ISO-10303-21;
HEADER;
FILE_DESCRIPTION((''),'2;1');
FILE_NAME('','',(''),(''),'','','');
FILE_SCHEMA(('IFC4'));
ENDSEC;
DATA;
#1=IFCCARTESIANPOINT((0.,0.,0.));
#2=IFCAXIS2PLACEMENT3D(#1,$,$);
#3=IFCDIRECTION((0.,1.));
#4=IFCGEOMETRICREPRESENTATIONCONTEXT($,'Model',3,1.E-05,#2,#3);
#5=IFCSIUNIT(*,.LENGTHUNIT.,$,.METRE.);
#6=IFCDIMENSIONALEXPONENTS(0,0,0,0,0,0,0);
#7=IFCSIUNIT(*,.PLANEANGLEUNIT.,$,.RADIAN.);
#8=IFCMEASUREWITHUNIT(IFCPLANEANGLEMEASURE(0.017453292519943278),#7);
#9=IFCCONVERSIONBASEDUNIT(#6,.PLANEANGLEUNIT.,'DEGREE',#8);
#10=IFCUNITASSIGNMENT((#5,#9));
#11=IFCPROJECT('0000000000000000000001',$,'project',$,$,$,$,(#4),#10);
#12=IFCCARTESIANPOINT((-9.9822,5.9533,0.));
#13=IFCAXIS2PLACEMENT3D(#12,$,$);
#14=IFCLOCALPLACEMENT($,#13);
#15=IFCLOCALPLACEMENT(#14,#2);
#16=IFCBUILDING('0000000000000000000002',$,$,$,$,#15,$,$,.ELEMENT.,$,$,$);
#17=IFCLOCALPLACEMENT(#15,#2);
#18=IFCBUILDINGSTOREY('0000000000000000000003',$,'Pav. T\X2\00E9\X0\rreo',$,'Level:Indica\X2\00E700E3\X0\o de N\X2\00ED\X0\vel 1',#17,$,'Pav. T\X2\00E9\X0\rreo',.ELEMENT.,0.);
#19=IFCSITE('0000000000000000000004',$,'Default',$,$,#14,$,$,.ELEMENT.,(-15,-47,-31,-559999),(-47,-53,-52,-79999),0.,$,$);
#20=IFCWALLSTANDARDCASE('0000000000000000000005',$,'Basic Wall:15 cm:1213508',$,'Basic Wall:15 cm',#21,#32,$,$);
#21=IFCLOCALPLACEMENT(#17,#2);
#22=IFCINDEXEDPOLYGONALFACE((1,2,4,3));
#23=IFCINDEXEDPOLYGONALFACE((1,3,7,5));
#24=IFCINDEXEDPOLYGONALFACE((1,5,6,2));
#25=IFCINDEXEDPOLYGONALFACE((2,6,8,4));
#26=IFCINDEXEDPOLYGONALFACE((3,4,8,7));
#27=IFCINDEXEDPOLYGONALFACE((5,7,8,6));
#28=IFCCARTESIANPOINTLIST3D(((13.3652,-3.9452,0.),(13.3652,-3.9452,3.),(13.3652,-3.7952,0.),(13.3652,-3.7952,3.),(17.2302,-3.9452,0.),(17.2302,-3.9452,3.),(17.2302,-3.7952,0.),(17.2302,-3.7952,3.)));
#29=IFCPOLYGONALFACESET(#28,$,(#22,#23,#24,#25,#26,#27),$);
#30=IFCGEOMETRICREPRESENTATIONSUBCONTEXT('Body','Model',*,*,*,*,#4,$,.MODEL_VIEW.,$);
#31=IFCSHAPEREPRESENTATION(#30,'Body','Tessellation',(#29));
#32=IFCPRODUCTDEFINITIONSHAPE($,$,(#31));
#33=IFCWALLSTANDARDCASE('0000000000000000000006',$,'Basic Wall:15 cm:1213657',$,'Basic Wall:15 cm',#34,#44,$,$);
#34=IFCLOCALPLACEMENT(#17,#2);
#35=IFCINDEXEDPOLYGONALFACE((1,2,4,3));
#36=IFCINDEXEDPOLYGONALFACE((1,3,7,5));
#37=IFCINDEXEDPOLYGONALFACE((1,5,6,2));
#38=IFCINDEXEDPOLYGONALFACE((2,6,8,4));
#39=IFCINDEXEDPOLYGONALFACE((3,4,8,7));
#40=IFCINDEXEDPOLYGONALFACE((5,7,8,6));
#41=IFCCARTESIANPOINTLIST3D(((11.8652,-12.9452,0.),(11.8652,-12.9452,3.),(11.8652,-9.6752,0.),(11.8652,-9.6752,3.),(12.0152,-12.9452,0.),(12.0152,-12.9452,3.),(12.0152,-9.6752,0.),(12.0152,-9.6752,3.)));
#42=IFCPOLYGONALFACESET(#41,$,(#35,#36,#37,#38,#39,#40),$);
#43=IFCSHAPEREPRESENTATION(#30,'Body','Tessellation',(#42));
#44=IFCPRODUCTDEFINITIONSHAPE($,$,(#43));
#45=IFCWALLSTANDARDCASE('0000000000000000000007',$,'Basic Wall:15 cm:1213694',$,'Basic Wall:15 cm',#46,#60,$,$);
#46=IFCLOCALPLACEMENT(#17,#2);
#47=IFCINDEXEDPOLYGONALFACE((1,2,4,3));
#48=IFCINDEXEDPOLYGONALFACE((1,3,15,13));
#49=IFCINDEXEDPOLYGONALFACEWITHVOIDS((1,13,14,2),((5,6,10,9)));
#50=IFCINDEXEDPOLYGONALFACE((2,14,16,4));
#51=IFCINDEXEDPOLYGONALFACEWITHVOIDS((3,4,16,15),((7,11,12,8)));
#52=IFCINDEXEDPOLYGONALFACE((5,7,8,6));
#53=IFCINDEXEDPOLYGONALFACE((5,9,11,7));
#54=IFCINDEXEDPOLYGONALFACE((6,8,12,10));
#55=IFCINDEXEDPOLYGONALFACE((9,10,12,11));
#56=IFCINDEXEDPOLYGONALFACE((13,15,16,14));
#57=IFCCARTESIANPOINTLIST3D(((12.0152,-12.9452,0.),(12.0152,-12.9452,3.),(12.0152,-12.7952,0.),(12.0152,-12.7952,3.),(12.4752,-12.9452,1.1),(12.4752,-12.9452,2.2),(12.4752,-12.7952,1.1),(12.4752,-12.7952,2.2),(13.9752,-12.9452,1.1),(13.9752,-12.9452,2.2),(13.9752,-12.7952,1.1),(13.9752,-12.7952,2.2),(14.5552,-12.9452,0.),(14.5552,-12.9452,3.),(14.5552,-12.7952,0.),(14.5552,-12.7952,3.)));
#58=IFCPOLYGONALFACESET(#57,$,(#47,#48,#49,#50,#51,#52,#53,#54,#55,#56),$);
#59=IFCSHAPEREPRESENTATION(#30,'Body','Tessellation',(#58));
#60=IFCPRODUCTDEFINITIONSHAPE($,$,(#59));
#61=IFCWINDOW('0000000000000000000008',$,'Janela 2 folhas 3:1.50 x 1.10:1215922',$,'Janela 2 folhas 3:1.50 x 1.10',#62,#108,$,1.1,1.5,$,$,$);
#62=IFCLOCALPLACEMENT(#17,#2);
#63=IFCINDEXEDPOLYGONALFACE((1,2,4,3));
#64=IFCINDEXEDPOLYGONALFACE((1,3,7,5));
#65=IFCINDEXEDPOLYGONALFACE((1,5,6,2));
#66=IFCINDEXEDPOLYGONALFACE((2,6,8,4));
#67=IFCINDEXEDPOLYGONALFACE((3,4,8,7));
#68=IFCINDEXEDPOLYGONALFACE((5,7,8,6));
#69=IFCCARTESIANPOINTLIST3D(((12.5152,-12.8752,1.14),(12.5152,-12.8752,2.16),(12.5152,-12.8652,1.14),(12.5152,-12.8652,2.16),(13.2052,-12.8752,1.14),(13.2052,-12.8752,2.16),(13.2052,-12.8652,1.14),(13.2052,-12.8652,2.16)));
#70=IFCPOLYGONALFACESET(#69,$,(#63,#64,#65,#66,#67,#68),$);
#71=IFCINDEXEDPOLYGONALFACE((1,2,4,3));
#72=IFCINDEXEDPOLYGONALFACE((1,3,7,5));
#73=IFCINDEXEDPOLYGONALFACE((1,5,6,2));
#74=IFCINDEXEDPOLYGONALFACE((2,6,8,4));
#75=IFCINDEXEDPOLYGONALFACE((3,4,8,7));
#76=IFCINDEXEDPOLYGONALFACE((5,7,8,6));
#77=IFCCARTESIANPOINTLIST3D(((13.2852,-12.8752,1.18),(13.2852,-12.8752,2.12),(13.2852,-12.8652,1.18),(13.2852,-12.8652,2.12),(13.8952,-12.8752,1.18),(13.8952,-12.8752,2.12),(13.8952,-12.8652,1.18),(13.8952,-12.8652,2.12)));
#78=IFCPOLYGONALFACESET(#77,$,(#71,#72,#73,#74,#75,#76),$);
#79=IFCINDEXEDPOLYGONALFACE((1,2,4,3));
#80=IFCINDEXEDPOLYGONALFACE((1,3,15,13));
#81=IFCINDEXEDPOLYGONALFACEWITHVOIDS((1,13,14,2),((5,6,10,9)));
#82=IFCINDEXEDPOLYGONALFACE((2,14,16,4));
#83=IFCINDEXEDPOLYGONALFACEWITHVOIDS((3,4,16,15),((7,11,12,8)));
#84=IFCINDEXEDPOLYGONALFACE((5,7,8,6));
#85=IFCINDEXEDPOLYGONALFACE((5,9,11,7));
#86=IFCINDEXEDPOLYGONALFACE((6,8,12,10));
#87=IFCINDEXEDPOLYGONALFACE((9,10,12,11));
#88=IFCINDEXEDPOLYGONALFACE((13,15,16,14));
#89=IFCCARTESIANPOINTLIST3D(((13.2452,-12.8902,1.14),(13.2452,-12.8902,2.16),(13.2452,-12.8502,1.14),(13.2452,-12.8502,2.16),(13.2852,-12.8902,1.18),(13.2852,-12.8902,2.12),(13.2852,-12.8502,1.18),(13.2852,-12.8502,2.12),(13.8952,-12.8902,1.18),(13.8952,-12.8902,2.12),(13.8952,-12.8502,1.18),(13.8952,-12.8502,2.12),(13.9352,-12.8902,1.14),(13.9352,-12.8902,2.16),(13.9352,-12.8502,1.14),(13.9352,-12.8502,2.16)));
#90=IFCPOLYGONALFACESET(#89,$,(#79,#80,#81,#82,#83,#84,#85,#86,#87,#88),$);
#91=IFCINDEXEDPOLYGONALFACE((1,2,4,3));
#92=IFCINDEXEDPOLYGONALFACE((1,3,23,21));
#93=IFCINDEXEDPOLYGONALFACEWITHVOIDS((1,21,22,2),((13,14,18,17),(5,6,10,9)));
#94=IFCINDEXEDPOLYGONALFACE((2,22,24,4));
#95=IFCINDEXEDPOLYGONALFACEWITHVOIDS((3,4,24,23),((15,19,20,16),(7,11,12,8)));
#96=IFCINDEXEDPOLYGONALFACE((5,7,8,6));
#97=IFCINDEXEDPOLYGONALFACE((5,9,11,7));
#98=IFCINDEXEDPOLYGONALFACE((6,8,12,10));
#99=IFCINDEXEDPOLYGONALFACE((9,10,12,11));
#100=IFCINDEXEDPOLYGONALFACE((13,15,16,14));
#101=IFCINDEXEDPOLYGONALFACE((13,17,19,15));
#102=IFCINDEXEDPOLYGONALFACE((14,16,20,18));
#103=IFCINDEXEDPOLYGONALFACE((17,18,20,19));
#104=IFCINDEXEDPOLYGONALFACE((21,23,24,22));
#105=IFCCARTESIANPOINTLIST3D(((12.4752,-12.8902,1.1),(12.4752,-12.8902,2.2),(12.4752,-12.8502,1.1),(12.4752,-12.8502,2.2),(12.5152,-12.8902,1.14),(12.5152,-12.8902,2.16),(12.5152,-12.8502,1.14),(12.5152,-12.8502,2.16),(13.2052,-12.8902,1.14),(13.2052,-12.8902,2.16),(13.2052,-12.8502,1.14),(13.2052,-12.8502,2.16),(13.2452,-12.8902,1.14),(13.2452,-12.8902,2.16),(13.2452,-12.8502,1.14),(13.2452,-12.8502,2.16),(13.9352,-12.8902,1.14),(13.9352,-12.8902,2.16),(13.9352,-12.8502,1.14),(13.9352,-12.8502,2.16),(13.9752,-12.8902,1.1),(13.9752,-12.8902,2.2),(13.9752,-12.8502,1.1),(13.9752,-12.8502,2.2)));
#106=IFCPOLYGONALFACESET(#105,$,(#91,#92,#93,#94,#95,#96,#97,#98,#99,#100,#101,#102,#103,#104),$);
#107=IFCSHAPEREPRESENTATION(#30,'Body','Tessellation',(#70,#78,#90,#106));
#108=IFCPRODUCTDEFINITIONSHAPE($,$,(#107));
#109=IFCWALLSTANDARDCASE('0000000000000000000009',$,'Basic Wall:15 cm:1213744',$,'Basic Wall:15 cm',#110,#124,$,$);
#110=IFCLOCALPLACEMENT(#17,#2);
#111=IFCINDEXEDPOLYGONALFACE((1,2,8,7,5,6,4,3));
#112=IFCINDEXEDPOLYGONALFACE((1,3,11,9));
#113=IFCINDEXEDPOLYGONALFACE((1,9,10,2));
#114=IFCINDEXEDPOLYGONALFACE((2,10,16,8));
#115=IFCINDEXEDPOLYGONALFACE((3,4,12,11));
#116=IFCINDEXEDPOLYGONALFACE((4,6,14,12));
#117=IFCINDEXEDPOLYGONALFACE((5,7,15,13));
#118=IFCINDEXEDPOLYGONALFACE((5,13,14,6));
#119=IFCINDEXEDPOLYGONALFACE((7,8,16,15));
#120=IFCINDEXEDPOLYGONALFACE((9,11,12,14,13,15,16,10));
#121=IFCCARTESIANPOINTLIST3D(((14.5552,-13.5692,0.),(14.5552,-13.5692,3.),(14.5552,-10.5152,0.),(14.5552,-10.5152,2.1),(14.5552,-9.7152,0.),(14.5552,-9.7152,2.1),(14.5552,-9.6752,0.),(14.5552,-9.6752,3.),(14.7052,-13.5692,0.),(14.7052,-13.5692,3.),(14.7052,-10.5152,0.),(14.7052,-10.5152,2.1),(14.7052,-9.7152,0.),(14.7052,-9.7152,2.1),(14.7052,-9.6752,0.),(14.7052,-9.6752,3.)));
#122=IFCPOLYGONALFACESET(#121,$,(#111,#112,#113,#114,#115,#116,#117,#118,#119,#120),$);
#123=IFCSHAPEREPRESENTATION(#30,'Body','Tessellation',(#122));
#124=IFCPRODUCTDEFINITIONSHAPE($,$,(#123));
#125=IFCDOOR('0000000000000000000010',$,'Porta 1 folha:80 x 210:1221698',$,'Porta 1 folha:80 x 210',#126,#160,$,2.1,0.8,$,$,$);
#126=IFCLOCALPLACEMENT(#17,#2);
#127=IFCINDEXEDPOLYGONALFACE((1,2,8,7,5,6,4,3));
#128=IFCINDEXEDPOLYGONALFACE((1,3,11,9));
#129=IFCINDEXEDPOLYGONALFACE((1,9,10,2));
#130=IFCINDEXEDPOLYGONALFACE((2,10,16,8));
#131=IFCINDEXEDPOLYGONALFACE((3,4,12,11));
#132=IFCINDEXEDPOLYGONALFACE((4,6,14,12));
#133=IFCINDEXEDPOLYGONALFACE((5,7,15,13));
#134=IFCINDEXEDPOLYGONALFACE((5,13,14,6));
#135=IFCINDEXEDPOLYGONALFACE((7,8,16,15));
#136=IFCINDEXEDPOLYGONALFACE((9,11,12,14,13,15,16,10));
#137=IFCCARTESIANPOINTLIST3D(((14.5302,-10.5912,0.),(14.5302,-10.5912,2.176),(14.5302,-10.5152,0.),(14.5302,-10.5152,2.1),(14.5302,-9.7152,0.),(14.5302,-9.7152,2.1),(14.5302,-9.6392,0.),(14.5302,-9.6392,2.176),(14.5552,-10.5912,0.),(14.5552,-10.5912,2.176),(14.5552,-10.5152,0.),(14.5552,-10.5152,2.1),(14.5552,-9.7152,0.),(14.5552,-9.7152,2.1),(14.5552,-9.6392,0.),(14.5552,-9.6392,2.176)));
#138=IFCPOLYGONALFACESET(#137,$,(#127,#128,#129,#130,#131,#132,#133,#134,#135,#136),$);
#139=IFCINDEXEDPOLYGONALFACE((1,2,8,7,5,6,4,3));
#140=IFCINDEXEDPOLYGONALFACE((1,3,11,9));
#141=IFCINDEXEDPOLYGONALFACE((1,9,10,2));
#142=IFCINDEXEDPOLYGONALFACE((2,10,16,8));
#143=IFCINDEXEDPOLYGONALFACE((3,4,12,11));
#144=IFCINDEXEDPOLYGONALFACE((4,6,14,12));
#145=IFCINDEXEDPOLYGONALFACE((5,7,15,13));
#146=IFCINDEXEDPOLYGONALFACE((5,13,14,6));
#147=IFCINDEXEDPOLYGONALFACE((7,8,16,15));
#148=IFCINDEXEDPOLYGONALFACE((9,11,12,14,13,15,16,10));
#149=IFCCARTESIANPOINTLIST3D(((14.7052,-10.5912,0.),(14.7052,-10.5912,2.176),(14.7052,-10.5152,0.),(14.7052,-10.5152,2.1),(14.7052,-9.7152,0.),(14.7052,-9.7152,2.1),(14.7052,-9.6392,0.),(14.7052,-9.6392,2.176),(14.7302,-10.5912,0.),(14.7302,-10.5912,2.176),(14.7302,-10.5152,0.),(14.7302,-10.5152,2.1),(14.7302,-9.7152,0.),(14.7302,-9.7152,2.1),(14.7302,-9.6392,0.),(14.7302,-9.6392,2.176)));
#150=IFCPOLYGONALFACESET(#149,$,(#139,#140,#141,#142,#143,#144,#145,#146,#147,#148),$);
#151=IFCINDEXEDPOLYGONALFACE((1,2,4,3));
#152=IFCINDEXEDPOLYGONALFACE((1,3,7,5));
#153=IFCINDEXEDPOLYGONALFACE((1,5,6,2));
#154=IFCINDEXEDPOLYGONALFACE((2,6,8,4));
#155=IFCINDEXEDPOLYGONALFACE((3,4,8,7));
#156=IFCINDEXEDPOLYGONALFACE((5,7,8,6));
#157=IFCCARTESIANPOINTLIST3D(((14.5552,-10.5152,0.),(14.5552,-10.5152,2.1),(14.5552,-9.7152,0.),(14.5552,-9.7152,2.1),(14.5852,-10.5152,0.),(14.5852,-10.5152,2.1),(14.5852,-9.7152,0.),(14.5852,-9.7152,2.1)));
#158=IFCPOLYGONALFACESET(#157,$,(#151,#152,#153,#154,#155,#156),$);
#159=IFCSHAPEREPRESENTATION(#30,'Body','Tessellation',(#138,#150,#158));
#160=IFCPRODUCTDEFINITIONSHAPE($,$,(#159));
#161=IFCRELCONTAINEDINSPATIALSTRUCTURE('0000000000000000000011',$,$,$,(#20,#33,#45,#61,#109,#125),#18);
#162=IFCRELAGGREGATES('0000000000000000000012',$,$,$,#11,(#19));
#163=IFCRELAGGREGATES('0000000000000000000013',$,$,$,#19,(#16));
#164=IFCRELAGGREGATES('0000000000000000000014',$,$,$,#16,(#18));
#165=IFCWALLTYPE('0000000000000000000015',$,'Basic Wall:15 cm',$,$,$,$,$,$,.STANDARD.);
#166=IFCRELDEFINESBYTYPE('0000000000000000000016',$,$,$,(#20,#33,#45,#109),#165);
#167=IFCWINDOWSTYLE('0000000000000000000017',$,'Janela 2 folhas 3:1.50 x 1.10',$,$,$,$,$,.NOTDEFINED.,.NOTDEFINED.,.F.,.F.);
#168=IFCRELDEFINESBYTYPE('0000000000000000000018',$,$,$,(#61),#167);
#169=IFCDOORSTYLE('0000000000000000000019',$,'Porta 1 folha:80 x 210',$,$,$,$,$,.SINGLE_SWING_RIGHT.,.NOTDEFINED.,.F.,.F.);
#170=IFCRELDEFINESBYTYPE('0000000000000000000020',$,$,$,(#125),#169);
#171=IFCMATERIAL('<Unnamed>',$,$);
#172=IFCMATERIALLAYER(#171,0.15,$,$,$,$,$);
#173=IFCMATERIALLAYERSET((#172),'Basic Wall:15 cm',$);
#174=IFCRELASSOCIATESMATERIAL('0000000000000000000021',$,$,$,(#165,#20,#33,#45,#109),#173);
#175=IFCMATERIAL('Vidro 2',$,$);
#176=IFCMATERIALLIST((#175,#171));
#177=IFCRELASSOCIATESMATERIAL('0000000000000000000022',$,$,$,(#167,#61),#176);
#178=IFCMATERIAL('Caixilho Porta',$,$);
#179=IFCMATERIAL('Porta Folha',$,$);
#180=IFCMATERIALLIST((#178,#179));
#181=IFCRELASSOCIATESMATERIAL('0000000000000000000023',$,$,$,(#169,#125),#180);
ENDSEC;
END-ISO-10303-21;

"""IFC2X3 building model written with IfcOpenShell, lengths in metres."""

from ifc_helpers import new_model, entity, si_unit, converted_unit, direction, frame, frame_2d, origin, origin_2d_with_axis, place, context, subcontext, project, spatial, polyline, rectangle, outline, extrude, source, transform, mapped, material, material_list, layer, layer_set, layer_usage, type_object, type_shapes, element, fill, save


model = new_model("IFC2X3")

# Units and contexts
model_context = context("Model", 3, precision=1e-05, world=origin(), true_north=direction((0.0, 1.0)))
body_context = subcontext(model_context, "Body", "Model", "MODEL_VIEW")
ifc_project = project(units=[si_unit("LENGTHUNIT", "METRE"), converted_unit("PLANEANGLEUNIT", "DEGREE", entity("IfcPlaneAngleMeasure", 0.017453292519943278), si_unit("PLANEANGLEUNIT", "RADIAN"), dimensions=[0, 0, 0, 0, 0, 0, 0])], contexts=[model_context])

# Site, building, storey
site_placement = place(None, frame((-9.9822, 5.9533, 0.0)))
site = spatial("IfcSite", under=ifc_project, at=site_placement, Name="Default", CompositionType="ELEMENT", RefLatitude=(-15, -47, -31, -559999), RefLongitude=(-47, -53, -52, -79999), RefElevation=0.0)
building_placement = place(site_placement, origin())
building = spatial("IfcBuilding", under=site, at=building_placement, CompositionType="ELEMENT")
storey_placement = place(building_placement, origin())
storey = spatial("IfcBuildingStorey", under=building, at=storey_placement, Name="Pav. Térreo", ObjectType="Level:Indicação de Nível 1", LongName="Pav. Térreo", CompositionType="ELEMENT", Elevation=0.0)

# Walls
ifc_material_1 = material(Name="<Unnamed>")
ifc_layer_1 = layer(ifc_material_1, 0.15)
ifc_layer_set_1 = layer_set([ifc_layer_1], Name="Basic Wall:15 cm")
ifc_layer_usage_1 = layer_usage(ifc_layer_set_1, "AXIS2", "NEGATIVE", 0.075)
wall_type = type_object("IfcWallType", Name="Basic Wall:15 cm", PredefinedType="STANDARD", material=ifc_layer_set_1)
wall_1_placement = place(storey_placement, frame((13.3652, -3.8702, 0.0)))
element("IfcWallStandardCase", 1, at=wall_1_placement, inside=storey, type_object=wall_type, material=ifc_layer_usage_1, Name="Basic Wall:15 cm:1213508", ObjectType="Basic Wall:15 cm", context=body_context, shape_type="SweptSolid", body=[
    extrude(rectangle(XDim=3.865, YDim=0.15, at=frame_2d((1.9325, 0.0), x_axis=(-1.0, 0.0))), origin(), (0.0, 0.0, 1.0), 3.0),
])
ifc_layer_usage_2 = layer_usage(ifc_layer_set_1, "AXIS2", "NEGATIVE", 0.075)
wall_2_placement = place(storey_placement, frame((11.9402, -9.6752, 0.0), z_axis=(0.0, 0.0, 1.0), x_axis=(0.0, -1.0, 0.0)))
element("IfcWallStandardCase", 2, at=wall_2_placement, inside=storey, type_object=wall_type, material=ifc_layer_usage_2, Name="Basic Wall:15 cm:1213657", ObjectType="Basic Wall:15 cm", context=body_context, shape_type="SweptSolid", body=[
    extrude(rectangle(XDim=3.27, YDim=0.15, at=frame_2d((1.635, 0.0), x_axis=(-1.0, 0.0))), origin(), (0.0, 0.0, 1.0), 3.0),
])

# Wall, opening, window
ifc_layer_usage_3 = layer_usage(ifc_layer_set_1, "AXIS2", "NEGATIVE", 0.075)
wall_3_placement = place(storey_placement, frame((12.0152, -12.8702, 0.0)))
wall_3 = element("IfcWallStandardCase", 3, at=wall_3_placement, inside=storey, type_object=wall_type, material=ifc_layer_usage_3, Name="Basic Wall:15 cm:1213694", ObjectType="Basic Wall:15 cm", context=body_context, shape_type="SweptSolid", body=[
    extrude(rectangle(XDim=2.54, YDim=0.15, at=frame_2d((1.27, 0.0), x_axis=(-1.0, 0.0))), origin(), (0.0, 0.0, 1.0), 3.0),
])
opening_1_placement = place(wall_3_placement, frame((0.46, -0.075, 1.1)))
opening_1 = element("IfcOpeningElement", 4, at=opening_1_placement, cuts=wall_3, ObjectType="Opening", context=body_context, shape_type="SweptSolid", body=[
    extrude(rectangle(XDim=1.1, YDim=1.5, at=frame_2d((0.55, 0.75), x_axis=(1.0, 0.0))), frame((0.0, 0.0, 0.0), z_axis=(0.0, 1.0, 0.0), x_axis=(0.0, 0.0, 1.0)), (0.0, 0.0, 1.0), 0.15),
])
ifc_material_2 = material(Name="Vidro 2")
ifc_material_list_1 = material_list([ifc_material_2, ifc_material_1])
window_style_1 = type_object("IfcWindowStyle", Name="Janela 2 folhas 3:1.50 x 1.10", ConstructionType="NOTDEFINED", OperationType="NOTDEFINED", ParameterTakesPrecedence=False, Sizeable=False, material=ifc_material_list_1)
shared_shape_1 = source(origin(), body_context, "Body", "SweptSolid", [
    extrude(rectangle(XDim=0.01, YDim=0.69, at=origin_2d_with_axis()), frame((0.385, 0.075, 0.04), z_axis=(0.0, 0.0, 1.0), x_axis=(0.0, 1.0, 0.0)), (0.0, 0.0, 1.0), 1.02),
    extrude(rectangle(XDim=0.01, YDim=0.61, at=origin_2d_with_axis()), frame((1.115, 0.075, 0.08), z_axis=(0.0, 0.0, 1.0), x_axis=(0.0, 1.0, 0.0)), (0.0, 0.0, 1.0), 0.94),
    extrude(outline(polyline([(-0.345, -0.51), (0.345, -0.51), (0.345, 0.51), (-0.345, 0.51), (-0.345, -0.51)]), holes=[polyline([(-0.305, -0.47), (-0.305, 0.47), (0.305, 0.47), (0.305, -0.47), (-0.305, -0.47)])]), frame((1.115, 0.055, 0.55), z_axis=(0.0, 1.0, 0.0), x_axis=(1.0, 0.0, 0.0)), (0.0, 0.0, 1.0), 0.04),
    extrude(outline(polyline([(-0.55, -0.75), (0.55, -0.75), (0.55, 0.75), (-0.55, 0.75), (-0.55, -0.75)]), holes=[polyline([(0.51, -0.02), (0.51, -0.71), (-0.51, -0.71), (-0.51, -0.02), (0.51, -0.02)]), polyline([(-0.51, 0.02), (-0.51, 0.71), (0.51, 0.71), (0.51, 0.02), (-0.51, 0.02)])]), frame((0.75, 0.055, 0.55), z_axis=(0.0, 1.0, 0.0), x_axis=(0.0, 0.0, -1.0)), (0.0, 0.0, 1.0), 0.04),
])
type_shapes(window_style_1, [shared_shape_1])
window_1_placement = place(opening_1_placement, origin())
window_1 = element("IfcWindow", 5, at=window_1_placement, inside=storey, type_object=window_style_1, material=ifc_material_list_1, Name="Janela 2 folhas 3:1.50 x 1.10:1215922", ObjectType="Janela 2 folhas 3:1.50 x 1.10", OverallHeight=1.1, OverallWidth=1.5, context=body_context, shape_type="MappedRepresentation", body=[
    mapped(shared_shape_1, transform((0.0, 0.0, 0.0), scale=1.0)),
])
fill(opening_1, window_1)

# Wall, opening, door
ifc_layer_usage_4 = layer_usage(ifc_layer_set_1, "AXIS2", "NEGATIVE", 0.075)
wall_4_placement = place(storey_placement, frame((14.6302, -13.5692, 0.0), z_axis=(0.0, 0.0, 1.0), x_axis=(0.0, 1.0, 0.0)))
wall_4 = element("IfcWallStandardCase", 6, at=wall_4_placement, inside=storey, type_object=wall_type, material=ifc_layer_usage_4, Name="Basic Wall:15 cm:1213744", ObjectType="Basic Wall:15 cm", context=body_context, shape_type="SweptSolid", body=[
    extrude(rectangle(XDim=3.894, YDim=0.15, at=frame_2d((1.947, 0.0), x_axis=(1.0, 0.0))), origin(), (0.0, 0.0, 1.0), 3.0),
])
opening_2_placement = place(wall_4_placement, frame((3.054, -0.075, 0.0)))
opening_2 = element("IfcOpeningElement", 7, at=opening_2_placement, cuts=wall_4, ObjectType="Opening", context=body_context, shape_type="SweptSolid", body=[
    extrude(rectangle(XDim=0.8, YDim=2.1, at=frame_2d((1.05, 0.4), x_axis=(0.0, 1.0))), frame((0.0, 0.0, 0.0), z_axis=(0.0, 1.0, 0.0), x_axis=(0.0, 0.0, 1.0)), (0.0, 0.0, 1.0), 0.15),
])
ifc_material_3 = material(Name="Caixilho Porta")
ifc_material_4 = material(Name="Porta Folha")
ifc_material_list_2 = material_list([ifc_material_3, ifc_material_4])
door_style_1 = type_object("IfcDoorStyle", Name="Porta 1 folha:80 x 210", ConstructionType="NOTDEFINED", OperationType="SINGLE_SWING_RIGHT", ParameterTakesPrecedence=False, Sizeable=False, material=ifc_material_list_2)
shared_shape_2 = source(origin(), body_context, "Body", "SweptSolid", [
    extrude(outline(polyline([(-0.476, -1.107), (0.476, -1.107), (0.476, 1.069), (0.4, 1.069), (0.4, -1.031), (-0.4, -1.031), (-0.4, 1.069), (-0.476, 1.069), (-0.476, -1.107)])), frame((0.4, 0.15, 1.069), z_axis=(0.0, 1.0, 0.0), x_axis=(1.0, 0.0, 0.0)), (0.0, 0.0, 1.0), 0.025),
    extrude(outline(polyline([(-1.107, -0.476), (1.069, -0.476), (1.069, -0.4), (-1.031, -0.4), (-1.031, 0.4), (1.069, 0.4), (1.069, 0.476), (-1.107, 0.476), (-1.107, -0.476)])), frame((0.4, -0.025, 1.069), z_axis=(0.0, 1.0, 0.0), x_axis=(0.0, 0.0, -1.0)), (0.0, 0.0, 1.0), 0.025),
    extrude(rectangle(XDim=0.03, YDim=0.8, at=origin_2d_with_axis()), frame((0.4, 0.135, 0.0), z_axis=(0.0, 0.0, 1.0), x_axis=(0.0, 1.0, 0.0)), (0.0, 0.0, 1.0), 2.1),
])
type_shapes(door_style_1, [shared_shape_2])
door_1_placement = place(opening_2_placement, origin())
door_1 = element("IfcDoor", 8, at=door_1_placement, inside=storey, type_object=door_style_1, material=ifc_material_list_2, Name="Porta 1 folha:80 x 210:1221698", ObjectType="Porta 1 folha:80 x 210", OverallHeight=2.1, OverallWidth=0.8, context=body_context, shape_type="MappedRepresentation", body=[
    mapped(shared_shape_2, transform((0.0, 0.0, 0.0), scale=1.0)),
])
fill(opening_2, door_1)

save(model, "model.ifc")
